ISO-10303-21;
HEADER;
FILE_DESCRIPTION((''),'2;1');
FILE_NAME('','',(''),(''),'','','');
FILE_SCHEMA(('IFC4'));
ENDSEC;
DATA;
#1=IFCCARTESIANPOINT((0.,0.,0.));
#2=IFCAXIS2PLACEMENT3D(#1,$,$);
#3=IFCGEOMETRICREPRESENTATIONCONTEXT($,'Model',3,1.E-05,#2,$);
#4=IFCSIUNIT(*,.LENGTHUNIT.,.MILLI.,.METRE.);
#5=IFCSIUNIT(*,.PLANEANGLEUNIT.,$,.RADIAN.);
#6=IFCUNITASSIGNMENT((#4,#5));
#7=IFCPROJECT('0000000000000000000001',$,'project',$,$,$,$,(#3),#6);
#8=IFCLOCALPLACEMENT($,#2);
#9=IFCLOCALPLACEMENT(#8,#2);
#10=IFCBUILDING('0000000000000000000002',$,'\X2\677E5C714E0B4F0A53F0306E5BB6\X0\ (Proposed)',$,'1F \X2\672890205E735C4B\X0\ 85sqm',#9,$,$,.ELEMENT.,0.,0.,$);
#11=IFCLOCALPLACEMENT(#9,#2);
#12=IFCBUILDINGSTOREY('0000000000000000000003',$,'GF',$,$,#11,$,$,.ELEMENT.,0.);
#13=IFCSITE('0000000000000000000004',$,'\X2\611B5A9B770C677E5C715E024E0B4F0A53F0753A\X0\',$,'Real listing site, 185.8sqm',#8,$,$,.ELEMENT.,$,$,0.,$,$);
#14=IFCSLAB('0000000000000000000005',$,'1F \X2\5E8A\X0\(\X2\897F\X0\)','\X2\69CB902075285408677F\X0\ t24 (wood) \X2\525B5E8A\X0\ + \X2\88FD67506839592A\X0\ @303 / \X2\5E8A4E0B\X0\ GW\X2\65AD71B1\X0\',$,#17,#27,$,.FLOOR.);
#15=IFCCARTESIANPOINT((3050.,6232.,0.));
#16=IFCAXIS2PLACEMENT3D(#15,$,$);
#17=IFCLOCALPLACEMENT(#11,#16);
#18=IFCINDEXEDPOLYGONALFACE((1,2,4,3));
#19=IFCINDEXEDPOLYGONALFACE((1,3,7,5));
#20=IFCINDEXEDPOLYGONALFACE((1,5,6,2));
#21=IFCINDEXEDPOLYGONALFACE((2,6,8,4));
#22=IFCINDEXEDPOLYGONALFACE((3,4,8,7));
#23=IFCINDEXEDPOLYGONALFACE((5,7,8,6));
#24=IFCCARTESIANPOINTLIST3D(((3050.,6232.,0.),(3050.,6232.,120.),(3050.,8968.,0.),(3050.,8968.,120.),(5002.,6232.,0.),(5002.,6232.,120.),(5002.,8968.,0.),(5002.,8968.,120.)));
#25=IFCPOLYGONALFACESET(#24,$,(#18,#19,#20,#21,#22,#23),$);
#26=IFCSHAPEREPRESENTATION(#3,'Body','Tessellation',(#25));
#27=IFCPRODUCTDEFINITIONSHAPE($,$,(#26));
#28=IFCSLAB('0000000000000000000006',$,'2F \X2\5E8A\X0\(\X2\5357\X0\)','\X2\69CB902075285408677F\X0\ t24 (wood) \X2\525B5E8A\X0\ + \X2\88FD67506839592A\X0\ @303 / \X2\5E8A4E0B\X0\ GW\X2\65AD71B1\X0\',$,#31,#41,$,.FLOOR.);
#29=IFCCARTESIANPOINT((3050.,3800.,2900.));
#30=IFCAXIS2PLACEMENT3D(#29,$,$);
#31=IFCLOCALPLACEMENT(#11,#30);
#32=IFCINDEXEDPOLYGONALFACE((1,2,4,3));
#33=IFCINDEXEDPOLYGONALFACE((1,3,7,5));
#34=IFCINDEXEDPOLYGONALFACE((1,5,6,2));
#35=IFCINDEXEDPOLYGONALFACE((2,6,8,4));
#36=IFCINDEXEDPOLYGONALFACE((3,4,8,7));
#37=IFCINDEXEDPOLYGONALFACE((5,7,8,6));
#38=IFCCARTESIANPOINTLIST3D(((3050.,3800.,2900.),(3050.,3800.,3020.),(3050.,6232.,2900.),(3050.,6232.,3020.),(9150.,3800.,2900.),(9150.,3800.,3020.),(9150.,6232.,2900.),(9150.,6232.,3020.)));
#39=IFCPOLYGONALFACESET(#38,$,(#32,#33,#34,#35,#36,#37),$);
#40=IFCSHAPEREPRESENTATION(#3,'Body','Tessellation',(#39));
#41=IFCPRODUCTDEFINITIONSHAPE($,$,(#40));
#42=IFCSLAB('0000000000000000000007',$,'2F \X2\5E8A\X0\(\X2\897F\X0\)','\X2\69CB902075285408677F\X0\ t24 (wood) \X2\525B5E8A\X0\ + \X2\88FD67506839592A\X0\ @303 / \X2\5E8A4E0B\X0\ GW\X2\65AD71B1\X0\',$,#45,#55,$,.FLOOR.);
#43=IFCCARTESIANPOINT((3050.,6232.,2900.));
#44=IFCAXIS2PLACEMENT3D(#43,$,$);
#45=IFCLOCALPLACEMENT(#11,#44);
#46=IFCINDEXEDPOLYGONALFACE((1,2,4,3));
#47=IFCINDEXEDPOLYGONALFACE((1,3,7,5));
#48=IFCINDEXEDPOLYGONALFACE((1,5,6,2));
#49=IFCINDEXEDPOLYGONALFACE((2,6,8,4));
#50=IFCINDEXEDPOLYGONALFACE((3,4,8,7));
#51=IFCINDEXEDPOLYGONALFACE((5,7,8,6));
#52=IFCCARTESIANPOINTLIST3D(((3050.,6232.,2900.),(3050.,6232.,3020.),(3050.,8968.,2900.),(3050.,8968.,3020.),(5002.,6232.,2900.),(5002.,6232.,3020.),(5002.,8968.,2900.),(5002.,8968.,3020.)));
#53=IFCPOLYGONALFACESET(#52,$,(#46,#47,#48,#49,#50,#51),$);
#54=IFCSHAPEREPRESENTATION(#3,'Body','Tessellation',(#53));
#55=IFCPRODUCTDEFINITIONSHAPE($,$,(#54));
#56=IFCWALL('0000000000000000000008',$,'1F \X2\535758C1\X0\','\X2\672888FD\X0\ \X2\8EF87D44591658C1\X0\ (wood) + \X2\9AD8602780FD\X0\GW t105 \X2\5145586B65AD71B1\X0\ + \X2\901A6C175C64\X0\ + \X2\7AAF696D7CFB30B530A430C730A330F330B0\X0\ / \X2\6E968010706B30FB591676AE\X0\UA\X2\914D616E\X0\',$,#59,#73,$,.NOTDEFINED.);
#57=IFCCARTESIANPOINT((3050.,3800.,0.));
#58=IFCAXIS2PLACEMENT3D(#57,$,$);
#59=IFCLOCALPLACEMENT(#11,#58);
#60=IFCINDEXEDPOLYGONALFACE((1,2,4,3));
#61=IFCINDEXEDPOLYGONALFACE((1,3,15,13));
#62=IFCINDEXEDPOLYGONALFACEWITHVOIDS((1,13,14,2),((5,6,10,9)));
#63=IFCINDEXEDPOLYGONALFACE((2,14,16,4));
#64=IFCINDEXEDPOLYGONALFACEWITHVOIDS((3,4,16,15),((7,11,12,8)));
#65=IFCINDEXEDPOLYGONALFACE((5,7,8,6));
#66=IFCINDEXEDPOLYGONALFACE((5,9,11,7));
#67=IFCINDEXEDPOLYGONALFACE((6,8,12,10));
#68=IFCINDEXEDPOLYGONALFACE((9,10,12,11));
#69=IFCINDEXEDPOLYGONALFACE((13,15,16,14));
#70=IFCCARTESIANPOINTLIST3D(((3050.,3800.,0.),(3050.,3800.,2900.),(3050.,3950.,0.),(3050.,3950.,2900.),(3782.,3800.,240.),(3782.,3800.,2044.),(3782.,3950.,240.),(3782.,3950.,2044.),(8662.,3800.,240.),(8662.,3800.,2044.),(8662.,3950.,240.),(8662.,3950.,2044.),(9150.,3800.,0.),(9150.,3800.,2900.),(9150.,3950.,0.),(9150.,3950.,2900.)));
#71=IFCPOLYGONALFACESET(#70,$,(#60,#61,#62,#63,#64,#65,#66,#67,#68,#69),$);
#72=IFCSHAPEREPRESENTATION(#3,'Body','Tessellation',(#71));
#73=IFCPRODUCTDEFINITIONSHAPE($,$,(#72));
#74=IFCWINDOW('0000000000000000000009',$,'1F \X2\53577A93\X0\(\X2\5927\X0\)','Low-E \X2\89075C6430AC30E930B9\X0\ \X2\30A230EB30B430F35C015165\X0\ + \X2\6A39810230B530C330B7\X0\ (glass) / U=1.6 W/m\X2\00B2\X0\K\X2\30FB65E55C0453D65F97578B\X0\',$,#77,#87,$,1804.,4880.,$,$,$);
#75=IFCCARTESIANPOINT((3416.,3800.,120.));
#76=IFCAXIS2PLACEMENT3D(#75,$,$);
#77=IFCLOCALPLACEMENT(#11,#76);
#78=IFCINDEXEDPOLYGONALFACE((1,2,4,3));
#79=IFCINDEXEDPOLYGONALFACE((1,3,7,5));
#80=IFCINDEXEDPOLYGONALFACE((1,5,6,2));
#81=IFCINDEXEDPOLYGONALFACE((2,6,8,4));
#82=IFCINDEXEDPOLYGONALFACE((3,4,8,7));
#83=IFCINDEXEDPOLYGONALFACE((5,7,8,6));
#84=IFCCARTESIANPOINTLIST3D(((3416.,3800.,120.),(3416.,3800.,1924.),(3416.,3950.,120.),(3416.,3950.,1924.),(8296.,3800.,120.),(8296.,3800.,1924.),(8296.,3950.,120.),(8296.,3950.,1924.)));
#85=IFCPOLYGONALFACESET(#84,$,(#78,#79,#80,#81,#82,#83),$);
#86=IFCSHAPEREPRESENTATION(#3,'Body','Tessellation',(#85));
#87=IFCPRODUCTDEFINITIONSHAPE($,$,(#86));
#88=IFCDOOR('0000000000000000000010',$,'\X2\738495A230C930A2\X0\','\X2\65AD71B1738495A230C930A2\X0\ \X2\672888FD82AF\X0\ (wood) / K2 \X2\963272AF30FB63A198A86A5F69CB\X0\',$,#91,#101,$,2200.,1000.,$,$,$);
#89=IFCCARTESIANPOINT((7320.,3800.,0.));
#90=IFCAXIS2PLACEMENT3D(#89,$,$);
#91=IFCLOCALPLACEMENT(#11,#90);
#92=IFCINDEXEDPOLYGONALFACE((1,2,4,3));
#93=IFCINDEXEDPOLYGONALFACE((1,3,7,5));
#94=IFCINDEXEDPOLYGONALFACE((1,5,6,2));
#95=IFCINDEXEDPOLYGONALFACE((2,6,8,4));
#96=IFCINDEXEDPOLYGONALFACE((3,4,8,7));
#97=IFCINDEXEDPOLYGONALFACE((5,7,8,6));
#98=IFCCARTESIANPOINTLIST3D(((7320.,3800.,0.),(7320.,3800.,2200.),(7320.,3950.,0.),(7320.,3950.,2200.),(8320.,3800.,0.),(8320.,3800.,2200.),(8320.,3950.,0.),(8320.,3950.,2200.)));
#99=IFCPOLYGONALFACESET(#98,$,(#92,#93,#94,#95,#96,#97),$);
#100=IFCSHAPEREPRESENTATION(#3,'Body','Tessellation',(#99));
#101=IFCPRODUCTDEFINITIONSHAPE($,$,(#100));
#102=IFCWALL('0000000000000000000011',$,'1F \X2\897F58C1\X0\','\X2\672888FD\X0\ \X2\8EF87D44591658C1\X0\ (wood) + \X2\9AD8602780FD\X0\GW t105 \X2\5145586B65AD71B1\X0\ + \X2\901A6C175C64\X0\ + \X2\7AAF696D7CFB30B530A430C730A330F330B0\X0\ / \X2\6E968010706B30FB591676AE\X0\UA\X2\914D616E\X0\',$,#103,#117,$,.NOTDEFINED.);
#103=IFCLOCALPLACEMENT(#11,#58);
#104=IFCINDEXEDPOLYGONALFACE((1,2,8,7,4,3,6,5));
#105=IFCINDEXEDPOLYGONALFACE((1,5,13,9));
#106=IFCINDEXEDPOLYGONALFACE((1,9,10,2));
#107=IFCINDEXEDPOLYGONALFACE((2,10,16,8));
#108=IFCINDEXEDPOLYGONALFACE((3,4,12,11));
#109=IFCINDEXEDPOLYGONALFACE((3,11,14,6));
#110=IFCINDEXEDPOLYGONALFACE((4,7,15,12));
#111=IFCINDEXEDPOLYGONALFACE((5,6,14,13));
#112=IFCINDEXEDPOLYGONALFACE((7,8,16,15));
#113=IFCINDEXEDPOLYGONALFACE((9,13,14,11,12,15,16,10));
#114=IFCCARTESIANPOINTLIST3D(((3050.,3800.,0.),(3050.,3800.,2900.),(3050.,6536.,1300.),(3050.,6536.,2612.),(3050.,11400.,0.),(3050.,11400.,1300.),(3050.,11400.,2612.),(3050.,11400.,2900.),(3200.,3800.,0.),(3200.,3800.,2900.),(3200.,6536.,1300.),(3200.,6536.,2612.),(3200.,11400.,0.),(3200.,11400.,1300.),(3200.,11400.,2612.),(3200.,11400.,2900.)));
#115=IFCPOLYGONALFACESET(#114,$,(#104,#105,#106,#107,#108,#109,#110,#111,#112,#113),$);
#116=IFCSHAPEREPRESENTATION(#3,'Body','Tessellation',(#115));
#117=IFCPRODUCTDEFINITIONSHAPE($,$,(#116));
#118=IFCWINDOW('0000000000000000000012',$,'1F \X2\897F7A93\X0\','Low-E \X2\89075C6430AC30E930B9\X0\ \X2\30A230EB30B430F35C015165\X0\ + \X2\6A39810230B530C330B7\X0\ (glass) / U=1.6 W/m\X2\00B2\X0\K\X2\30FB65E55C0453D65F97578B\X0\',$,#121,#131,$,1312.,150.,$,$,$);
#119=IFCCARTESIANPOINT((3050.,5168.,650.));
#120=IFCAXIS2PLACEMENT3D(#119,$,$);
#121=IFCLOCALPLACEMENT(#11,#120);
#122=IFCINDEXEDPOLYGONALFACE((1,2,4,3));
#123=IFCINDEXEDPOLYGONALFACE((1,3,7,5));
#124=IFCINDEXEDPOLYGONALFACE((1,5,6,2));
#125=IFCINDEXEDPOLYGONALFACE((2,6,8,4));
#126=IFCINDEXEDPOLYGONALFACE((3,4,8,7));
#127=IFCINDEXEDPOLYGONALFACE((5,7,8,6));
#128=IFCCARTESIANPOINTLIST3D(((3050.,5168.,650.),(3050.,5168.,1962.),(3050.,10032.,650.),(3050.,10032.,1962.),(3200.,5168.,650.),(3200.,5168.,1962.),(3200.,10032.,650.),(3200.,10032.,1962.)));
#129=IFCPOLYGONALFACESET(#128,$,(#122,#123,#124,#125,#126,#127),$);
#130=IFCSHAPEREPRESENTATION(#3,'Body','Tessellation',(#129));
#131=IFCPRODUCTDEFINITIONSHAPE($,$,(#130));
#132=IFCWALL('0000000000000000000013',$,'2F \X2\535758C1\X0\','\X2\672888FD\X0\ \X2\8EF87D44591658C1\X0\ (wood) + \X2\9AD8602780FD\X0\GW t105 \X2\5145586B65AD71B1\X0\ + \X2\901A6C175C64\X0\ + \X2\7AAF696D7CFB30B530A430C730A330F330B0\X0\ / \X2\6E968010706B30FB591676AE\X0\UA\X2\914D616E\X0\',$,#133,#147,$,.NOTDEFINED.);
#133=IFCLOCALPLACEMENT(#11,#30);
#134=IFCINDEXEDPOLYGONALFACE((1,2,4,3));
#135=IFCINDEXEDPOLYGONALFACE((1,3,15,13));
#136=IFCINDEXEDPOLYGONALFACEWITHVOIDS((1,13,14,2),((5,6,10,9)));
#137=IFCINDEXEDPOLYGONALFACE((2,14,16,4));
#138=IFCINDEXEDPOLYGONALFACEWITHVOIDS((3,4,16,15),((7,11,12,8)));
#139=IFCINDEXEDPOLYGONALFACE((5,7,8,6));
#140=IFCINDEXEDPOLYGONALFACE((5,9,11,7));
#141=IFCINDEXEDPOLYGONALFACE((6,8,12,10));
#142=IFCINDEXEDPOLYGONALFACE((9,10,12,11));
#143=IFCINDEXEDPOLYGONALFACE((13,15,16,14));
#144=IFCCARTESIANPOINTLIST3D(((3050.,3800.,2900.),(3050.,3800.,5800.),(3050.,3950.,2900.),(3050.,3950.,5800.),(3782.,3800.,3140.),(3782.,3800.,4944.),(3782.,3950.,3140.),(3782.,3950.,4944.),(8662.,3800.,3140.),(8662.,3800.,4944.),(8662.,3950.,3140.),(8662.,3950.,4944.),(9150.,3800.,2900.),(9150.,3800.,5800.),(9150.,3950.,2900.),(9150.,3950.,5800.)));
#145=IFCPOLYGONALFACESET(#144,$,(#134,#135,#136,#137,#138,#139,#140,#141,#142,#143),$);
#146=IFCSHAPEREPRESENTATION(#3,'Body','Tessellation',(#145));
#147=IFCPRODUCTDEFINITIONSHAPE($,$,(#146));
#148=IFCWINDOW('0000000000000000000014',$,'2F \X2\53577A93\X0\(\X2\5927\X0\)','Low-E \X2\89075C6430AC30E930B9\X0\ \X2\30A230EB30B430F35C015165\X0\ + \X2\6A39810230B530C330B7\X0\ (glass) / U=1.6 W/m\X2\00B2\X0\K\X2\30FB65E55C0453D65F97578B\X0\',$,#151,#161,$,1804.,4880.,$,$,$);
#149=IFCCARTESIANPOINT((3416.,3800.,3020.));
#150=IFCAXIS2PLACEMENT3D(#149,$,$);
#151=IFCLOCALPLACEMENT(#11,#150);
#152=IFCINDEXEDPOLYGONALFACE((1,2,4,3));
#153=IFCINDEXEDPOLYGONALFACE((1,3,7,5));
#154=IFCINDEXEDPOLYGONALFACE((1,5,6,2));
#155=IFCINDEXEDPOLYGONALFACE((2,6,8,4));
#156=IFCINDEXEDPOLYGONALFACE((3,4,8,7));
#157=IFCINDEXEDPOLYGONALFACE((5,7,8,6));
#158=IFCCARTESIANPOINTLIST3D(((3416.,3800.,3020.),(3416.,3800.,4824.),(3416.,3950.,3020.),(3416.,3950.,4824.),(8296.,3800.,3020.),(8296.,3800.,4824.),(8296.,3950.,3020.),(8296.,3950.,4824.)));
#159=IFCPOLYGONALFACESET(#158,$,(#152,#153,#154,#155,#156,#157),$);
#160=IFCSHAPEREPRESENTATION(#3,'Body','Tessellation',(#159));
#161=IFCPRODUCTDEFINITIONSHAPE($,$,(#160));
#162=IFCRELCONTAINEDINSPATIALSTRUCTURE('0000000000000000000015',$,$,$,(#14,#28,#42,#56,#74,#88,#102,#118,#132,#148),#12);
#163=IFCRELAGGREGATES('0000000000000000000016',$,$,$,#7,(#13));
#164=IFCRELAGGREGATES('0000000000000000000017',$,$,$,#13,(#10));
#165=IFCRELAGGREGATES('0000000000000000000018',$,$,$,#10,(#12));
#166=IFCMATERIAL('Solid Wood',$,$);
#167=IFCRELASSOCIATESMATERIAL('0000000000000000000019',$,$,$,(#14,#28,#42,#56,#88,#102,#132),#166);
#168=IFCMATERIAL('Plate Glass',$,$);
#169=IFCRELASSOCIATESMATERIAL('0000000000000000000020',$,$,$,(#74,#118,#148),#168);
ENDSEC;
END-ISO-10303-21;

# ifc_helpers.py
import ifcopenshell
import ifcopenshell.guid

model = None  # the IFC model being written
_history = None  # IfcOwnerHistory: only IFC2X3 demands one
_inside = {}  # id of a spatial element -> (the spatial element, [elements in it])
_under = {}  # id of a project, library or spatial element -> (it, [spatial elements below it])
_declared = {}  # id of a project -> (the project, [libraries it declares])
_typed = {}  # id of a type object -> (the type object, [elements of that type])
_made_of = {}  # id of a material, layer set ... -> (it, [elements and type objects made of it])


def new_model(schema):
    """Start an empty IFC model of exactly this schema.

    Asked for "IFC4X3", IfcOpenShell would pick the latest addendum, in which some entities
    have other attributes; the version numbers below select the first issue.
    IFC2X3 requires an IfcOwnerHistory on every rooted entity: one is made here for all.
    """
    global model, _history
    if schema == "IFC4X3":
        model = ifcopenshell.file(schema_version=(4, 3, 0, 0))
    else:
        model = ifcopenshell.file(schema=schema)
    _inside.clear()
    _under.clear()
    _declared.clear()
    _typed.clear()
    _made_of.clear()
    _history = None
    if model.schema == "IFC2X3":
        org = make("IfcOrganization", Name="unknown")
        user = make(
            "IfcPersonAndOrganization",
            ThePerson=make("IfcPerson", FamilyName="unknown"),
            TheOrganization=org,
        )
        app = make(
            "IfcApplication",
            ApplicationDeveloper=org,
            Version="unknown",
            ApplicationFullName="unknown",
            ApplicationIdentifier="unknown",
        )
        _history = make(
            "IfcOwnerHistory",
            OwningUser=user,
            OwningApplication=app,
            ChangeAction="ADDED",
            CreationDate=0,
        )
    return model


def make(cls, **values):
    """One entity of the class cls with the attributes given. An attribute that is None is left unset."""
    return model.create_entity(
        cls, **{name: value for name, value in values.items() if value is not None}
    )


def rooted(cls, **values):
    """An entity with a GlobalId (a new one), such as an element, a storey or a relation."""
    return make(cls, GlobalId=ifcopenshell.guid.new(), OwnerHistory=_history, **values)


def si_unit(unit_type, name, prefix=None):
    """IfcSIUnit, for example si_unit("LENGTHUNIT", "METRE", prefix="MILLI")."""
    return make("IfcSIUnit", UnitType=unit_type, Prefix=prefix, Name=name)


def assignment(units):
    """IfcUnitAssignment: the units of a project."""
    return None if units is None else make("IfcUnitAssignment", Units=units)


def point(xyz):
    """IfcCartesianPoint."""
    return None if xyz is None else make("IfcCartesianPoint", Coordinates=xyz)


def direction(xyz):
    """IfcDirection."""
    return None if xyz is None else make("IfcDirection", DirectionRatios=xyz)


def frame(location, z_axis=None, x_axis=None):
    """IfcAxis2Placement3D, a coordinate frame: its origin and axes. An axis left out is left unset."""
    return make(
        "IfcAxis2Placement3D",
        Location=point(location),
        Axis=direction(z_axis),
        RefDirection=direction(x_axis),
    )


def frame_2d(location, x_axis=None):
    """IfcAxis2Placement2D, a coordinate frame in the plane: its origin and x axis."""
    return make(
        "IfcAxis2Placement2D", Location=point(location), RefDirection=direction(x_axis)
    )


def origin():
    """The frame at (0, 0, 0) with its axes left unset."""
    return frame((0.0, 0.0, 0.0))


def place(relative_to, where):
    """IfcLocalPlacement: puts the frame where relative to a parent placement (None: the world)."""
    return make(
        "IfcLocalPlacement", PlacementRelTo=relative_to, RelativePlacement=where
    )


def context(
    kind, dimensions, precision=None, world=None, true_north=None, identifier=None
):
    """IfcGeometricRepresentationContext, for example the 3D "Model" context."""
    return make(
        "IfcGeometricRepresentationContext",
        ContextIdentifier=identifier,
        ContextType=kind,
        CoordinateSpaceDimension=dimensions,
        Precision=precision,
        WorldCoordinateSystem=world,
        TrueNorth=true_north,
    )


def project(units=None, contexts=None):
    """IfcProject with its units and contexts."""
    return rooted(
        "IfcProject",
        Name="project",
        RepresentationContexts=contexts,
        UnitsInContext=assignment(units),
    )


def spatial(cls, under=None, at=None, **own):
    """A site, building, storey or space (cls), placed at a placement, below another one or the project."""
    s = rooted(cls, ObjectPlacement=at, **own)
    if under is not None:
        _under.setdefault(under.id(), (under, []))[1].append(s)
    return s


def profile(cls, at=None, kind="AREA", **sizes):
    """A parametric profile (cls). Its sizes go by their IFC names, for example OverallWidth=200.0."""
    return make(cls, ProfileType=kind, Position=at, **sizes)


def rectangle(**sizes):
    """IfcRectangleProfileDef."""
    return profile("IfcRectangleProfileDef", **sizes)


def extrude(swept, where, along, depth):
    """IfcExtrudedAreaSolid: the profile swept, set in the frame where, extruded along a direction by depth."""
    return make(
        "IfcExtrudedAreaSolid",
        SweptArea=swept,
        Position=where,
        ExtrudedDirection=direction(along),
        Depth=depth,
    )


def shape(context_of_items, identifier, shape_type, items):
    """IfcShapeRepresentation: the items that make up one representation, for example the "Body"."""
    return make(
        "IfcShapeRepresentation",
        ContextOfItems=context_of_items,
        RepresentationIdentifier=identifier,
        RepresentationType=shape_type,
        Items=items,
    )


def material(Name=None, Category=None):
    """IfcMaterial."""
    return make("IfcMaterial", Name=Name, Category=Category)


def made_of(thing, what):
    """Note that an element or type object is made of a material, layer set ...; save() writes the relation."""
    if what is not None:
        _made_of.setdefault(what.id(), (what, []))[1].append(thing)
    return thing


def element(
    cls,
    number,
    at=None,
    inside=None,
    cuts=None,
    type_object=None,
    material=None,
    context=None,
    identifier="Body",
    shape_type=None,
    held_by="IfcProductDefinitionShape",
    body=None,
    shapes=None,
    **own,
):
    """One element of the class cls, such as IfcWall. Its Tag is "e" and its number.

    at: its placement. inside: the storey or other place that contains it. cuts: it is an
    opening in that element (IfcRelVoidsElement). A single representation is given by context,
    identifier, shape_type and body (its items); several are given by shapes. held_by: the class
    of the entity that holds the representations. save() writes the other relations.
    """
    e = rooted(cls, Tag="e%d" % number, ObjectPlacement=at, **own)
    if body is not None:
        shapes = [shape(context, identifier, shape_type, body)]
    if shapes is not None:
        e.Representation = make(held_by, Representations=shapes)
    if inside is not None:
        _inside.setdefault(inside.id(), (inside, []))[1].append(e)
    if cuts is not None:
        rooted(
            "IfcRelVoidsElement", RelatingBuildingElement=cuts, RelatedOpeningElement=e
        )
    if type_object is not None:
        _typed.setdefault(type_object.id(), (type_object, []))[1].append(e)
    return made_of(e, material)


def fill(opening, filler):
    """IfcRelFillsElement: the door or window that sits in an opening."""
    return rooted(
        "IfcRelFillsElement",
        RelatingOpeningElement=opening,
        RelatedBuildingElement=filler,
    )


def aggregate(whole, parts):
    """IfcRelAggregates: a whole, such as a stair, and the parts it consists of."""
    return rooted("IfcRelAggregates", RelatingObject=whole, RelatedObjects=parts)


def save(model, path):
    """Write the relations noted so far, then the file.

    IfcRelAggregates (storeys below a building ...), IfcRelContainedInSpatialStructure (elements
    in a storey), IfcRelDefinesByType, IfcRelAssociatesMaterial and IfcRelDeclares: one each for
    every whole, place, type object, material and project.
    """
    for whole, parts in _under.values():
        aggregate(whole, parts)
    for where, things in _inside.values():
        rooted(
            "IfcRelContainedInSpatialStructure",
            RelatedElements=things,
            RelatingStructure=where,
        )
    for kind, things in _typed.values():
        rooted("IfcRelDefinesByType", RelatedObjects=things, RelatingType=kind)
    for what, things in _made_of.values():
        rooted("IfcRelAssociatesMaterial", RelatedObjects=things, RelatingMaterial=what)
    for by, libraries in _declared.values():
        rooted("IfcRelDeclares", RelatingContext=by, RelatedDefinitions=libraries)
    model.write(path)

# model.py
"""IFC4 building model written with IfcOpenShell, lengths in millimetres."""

from ifc_helpers import new_model, si_unit, frame, frame_2d, origin, place, context, project, spatial, rectangle, extrude, material, element, fill, save


model = new_model("IFC4")

# Units and contexts
model_context = context("Model", 3, precision=1e-05, world=origin())
ifc_project = project(units=[si_unit("LENGTHUNIT", "METRE", prefix="MILLI"), si_unit("PLANEANGLEUNIT", "RADIAN")], contexts=[model_context])

# Site, building, storey
site_placement = place(None, origin())
site = spatial("IfcSite", under=ifc_project, at=site_placement, Name="愛媛県松山市下伊台町", ObjectType="Real listing site, 185.8sqm", CompositionType="ELEMENT", RefElevation=0.0)
building_placement = place(site_placement, origin())
building = spatial("IfcBuilding", under=site, at=building_placement, Name="松山下伊台の家 (Proposed)", ObjectType="1F 木造平屋 85sqm", CompositionType="ELEMENT", ElevationOfRefHeight=0.0, ElevationOfTerrain=0.0)
storey_placement = place(building_placement, origin())
storey = spatial("IfcBuildingStorey", under=building, at=storey_placement, Name="GF", CompositionType="ELEMENT", Elevation=0.0)

# Slabs
ifc_material_1 = material(Name="Solid Wood")
slab_1_placement = place(storey_placement, frame((3050.0, 6232.0, 0.0)))
element("IfcSlab", 1, at=slab_1_placement, inside=storey, material=ifc_material_1, Name="1F 床(西)", Description="構造用合板 t24 (wood) 剛床 + 製材根太 @303 / 床下 GW断熱", PredefinedType="FLOOR", context=model_context, shape_type="SweptSolid", body=[
    extrude(rectangle(XDim=1952.0, YDim=2736.0, at=frame_2d((976.0, 1368.0))), frame((3050.0, 6232.0, 0.0)), (0.0, 0.0, 1.0), 120.0),
])
slab_2_placement = place(storey_placement, frame((3050.0, 3800.0, 2900.0)))
element("IfcSlab", 2, at=slab_2_placement, inside=storey, material=ifc_material_1, Name="2F 床(南)", Description="構造用合板 t24 (wood) 剛床 + 製材根太 @303 / 床下 GW断熱", PredefinedType="FLOOR", context=model_context, shape_type="SweptSolid", body=[
    extrude(rectangle(XDim=6100.0, YDim=2432.0, at=frame_2d((3050.0, 1216.0))), frame((3050.0, 3800.0, 2900.0)), (0.0, 0.0, 1.0), 120.0),
])
slab_3_placement = place(storey_placement, frame((3050.0, 6232.0, 2900.0)))
element("IfcSlab", 3, at=slab_3_placement, inside=storey, material=ifc_material_1, Name="2F 床(西)", Description="構造用合板 t24 (wood) 剛床 + 製材根太 @303 / 床下 GW断熱", PredefinedType="FLOOR", context=model_context, shape_type="SweptSolid", body=[
    extrude(rectangle(XDim=1952.0, YDim=2736.0, at=frame_2d((976.0, 1368.0))), frame((3050.0, 6232.0, 2900.0)), (0.0, 0.0, 1.0), 120.0),
])

# Wall, openings, window, door
wall_1_placement = place(storey_placement, frame((3050.0, 3800.0, 0.0)))
wall_1 = element("IfcWall", 4, at=wall_1_placement, inside=storey, material=ifc_material_1, Name="1F 南壁", Description="木製 軸組外壁 (wood) + 高性能GW t105 充填断熱 + 通気層 + 窯業系サイディング / 準耐火・外皮UA配慮", PredefinedType="NOTDEFINED", context=model_context, shape_type="SweptSolid", body=[
    extrude(rectangle(XDim=6100.0, YDim=150.0, at=frame_2d((3050.0, 75.0))), frame((3050.0, 3800.0, 0.0)), (0.0, 0.0, 1.0), 2900.0),
])
opening_1_placement = place(storey_placement, frame((3416.0, 3800.0, 120.0)))
opening_1 = element("IfcOpeningElement", 5, at=opening_1_placement, cuts=wall_1, PredefinedType="NOTDEFINED", context=model_context, shape_type="SweptSolid", body=[
    extrude(rectangle(XDim=4880.0, YDim=150.0, at=frame_2d((2440.0, 75.0))), frame((3416.0, 3800.0, 120.0)), (0.0, 0.0, 1.0), 1804.0),
])
opening_2_placement = place(storey_placement, frame((7320.0, 3800.0, 0.0)))
opening_2 = element("IfcOpeningElement", 6, at=opening_2_placement, cuts=wall_1, PredefinedType="NOTDEFINED", context=model_context, shape_type="SweptSolid", body=[
    extrude(rectangle(XDim=1000.0, YDim=150.0, at=frame_2d((500.0, 75.0))), frame((7320.0, 3800.0, 0.0)), (0.0, 0.0, 1.0), 2200.0),
])
ifc_material_2 = material(Name="Plate Glass")
window_1_placement = place(storey_placement, frame((3416.0, 3800.0, 120.0)))
window_1 = element("IfcWindow", 7, at=window_1_placement, inside=storey, material=ifc_material_2, Name="1F 南窓(大)", Description="Low-E 複層ガラス アルゴン封入 + 樹脂サッシ (glass) / U=1.6 W/m²K・日射取得型", OverallHeight=1804.0, OverallWidth=4880.0, context=model_context, shape_type="SweptSolid", body=[
    extrude(rectangle(XDim=4880.0, YDim=150.0, at=frame_2d((2440.0, 75.0))), frame((3416.0, 3800.0, 120.0)), (0.0, 0.0, 1.0), 1804.0),
])
fill(opening_1, window_1)
door_placement = place(storey_placement, frame((7320.0, 3800.0, 0.0)))
door = element("IfcDoor", 8, at=door_placement, inside=storey, material=ifc_material_1, Name="玄関ドア", Description="断熱玄関ドア 木製芯 (wood) / K2 防犯・採風機構", OverallHeight=2200.0, OverallWidth=1000.0, context=model_context, shape_type="SweptSolid", body=[
    extrude(rectangle(XDim=1000.0, YDim=150.0, at=frame_2d((500.0, 75.0))), frame((7320.0, 3800.0, 0.0)), (0.0, 0.0, 1.0), 2200.0),
])
fill(opening_2, door)

# Walls, openings, windows
wall_2_placement = place(storey_placement, frame((3050.0, 3800.0, 0.0)))
wall_2 = element("IfcWall", 9, at=wall_2_placement, inside=storey, material=ifc_material_1, Name="1F 西壁", Description="木製 軸組外壁 (wood) + 高性能GW t105 充填断熱 + 通気層 + 窯業系サイディング / 準耐火・外皮UA配慮", PredefinedType="NOTDEFINED", context=model_context, shape_type="SweptSolid", body=[
    extrude(rectangle(XDim=150.0, YDim=7600.0, at=frame_2d((75.0, 3800.0))), frame((3050.0, 3800.0, 0.0)), (0.0, 0.0, 1.0), 2900.0),
])
opening_3_placement = place(storey_placement, frame((3050.0, 5168.0, 650.0)))
opening_3 = element("IfcOpeningElement", 10, at=opening_3_placement, cuts=wall_2, PredefinedType="NOTDEFINED", context=model_context, shape_type="SweptSolid", body=[
    extrude(rectangle(XDim=150.0, YDim=4864.0, at=frame_2d((75.0, 2432.0))), frame((3050.0, 5168.0, 650.0)), (0.0, 0.0, 1.0), 1312.0),
])
window_2_placement = place(storey_placement, frame((3050.0, 5168.0, 650.0)))
window_2 = element("IfcWindow", 11, at=window_2_placement, inside=storey, material=ifc_material_2, Name="1F 西窓", Description="Low-E 複層ガラス アルゴン封入 + 樹脂サッシ (glass) / U=1.6 W/m²K・日射取得型", OverallHeight=1312.0, OverallWidth=150.0, context=model_context, shape_type="SweptSolid", body=[
    extrude(rectangle(XDim=150.0, YDim=4864.0, at=frame_2d((75.0, 2432.0))), frame((3050.0, 5168.0, 650.0)), (0.0, 0.0, 1.0), 1312.0),
])
fill(opening_3, window_2)
wall_3_placement = place(storey_placement, frame((3050.0, 3800.0, 2900.0)))
wall_3 = element("IfcWall", 12, at=wall_3_placement, inside=storey, material=ifc_material_1, Name="2F 南壁", Description="木製 軸組外壁 (wood) + 高性能GW t105 充填断熱 + 通気層 + 窯業系サイディング / 準耐火・外皮UA配慮", PredefinedType="NOTDEFINED", context=model_context, shape_type="SweptSolid", body=[
    extrude(rectangle(XDim=6100.0, YDim=150.0, at=frame_2d((3050.0, 75.0))), frame((3050.0, 3800.0, 2900.0)), (0.0, 0.0, 1.0), 2900.0),
])
opening_4_placement = place(storey_placement, frame((3416.0, 3800.0, 3020.0)))
opening_4 = element("IfcOpeningElement", 13, at=opening_4_placement, cuts=wall_3, PredefinedType="NOTDEFINED", context=model_context, shape_type="SweptSolid", body=[
    extrude(rectangle(XDim=4880.0, YDim=150.0, at=frame_2d((2440.0, 75.0))), frame((3416.0, 3800.0, 3020.0)), (0.0, 0.0, 1.0), 1804.0),
])
window_3_placement = place(storey_placement, frame((3416.0, 3800.0, 3020.0)))
window_3 = element("IfcWindow", 14, at=window_3_placement, inside=storey, material=ifc_material_2, Name="2F 南窓(大)", Description="Low-E 複層ガラス アルゴン封入 + 樹脂サッシ (glass) / U=1.6 W/m²K・日射取得型", OverallHeight=1804.0, OverallWidth=4880.0, context=model_context, shape_type="SweptSolid", body=[
    extrude(rectangle(XDim=4880.0, YDim=150.0, at=frame_2d((2440.0, 75.0))), frame((3416.0, 3800.0, 3020.0)), (0.0, 0.0, 1.0), 1804.0),
])
fill(opening_4, window_3)

save(model, "model.ifc")
